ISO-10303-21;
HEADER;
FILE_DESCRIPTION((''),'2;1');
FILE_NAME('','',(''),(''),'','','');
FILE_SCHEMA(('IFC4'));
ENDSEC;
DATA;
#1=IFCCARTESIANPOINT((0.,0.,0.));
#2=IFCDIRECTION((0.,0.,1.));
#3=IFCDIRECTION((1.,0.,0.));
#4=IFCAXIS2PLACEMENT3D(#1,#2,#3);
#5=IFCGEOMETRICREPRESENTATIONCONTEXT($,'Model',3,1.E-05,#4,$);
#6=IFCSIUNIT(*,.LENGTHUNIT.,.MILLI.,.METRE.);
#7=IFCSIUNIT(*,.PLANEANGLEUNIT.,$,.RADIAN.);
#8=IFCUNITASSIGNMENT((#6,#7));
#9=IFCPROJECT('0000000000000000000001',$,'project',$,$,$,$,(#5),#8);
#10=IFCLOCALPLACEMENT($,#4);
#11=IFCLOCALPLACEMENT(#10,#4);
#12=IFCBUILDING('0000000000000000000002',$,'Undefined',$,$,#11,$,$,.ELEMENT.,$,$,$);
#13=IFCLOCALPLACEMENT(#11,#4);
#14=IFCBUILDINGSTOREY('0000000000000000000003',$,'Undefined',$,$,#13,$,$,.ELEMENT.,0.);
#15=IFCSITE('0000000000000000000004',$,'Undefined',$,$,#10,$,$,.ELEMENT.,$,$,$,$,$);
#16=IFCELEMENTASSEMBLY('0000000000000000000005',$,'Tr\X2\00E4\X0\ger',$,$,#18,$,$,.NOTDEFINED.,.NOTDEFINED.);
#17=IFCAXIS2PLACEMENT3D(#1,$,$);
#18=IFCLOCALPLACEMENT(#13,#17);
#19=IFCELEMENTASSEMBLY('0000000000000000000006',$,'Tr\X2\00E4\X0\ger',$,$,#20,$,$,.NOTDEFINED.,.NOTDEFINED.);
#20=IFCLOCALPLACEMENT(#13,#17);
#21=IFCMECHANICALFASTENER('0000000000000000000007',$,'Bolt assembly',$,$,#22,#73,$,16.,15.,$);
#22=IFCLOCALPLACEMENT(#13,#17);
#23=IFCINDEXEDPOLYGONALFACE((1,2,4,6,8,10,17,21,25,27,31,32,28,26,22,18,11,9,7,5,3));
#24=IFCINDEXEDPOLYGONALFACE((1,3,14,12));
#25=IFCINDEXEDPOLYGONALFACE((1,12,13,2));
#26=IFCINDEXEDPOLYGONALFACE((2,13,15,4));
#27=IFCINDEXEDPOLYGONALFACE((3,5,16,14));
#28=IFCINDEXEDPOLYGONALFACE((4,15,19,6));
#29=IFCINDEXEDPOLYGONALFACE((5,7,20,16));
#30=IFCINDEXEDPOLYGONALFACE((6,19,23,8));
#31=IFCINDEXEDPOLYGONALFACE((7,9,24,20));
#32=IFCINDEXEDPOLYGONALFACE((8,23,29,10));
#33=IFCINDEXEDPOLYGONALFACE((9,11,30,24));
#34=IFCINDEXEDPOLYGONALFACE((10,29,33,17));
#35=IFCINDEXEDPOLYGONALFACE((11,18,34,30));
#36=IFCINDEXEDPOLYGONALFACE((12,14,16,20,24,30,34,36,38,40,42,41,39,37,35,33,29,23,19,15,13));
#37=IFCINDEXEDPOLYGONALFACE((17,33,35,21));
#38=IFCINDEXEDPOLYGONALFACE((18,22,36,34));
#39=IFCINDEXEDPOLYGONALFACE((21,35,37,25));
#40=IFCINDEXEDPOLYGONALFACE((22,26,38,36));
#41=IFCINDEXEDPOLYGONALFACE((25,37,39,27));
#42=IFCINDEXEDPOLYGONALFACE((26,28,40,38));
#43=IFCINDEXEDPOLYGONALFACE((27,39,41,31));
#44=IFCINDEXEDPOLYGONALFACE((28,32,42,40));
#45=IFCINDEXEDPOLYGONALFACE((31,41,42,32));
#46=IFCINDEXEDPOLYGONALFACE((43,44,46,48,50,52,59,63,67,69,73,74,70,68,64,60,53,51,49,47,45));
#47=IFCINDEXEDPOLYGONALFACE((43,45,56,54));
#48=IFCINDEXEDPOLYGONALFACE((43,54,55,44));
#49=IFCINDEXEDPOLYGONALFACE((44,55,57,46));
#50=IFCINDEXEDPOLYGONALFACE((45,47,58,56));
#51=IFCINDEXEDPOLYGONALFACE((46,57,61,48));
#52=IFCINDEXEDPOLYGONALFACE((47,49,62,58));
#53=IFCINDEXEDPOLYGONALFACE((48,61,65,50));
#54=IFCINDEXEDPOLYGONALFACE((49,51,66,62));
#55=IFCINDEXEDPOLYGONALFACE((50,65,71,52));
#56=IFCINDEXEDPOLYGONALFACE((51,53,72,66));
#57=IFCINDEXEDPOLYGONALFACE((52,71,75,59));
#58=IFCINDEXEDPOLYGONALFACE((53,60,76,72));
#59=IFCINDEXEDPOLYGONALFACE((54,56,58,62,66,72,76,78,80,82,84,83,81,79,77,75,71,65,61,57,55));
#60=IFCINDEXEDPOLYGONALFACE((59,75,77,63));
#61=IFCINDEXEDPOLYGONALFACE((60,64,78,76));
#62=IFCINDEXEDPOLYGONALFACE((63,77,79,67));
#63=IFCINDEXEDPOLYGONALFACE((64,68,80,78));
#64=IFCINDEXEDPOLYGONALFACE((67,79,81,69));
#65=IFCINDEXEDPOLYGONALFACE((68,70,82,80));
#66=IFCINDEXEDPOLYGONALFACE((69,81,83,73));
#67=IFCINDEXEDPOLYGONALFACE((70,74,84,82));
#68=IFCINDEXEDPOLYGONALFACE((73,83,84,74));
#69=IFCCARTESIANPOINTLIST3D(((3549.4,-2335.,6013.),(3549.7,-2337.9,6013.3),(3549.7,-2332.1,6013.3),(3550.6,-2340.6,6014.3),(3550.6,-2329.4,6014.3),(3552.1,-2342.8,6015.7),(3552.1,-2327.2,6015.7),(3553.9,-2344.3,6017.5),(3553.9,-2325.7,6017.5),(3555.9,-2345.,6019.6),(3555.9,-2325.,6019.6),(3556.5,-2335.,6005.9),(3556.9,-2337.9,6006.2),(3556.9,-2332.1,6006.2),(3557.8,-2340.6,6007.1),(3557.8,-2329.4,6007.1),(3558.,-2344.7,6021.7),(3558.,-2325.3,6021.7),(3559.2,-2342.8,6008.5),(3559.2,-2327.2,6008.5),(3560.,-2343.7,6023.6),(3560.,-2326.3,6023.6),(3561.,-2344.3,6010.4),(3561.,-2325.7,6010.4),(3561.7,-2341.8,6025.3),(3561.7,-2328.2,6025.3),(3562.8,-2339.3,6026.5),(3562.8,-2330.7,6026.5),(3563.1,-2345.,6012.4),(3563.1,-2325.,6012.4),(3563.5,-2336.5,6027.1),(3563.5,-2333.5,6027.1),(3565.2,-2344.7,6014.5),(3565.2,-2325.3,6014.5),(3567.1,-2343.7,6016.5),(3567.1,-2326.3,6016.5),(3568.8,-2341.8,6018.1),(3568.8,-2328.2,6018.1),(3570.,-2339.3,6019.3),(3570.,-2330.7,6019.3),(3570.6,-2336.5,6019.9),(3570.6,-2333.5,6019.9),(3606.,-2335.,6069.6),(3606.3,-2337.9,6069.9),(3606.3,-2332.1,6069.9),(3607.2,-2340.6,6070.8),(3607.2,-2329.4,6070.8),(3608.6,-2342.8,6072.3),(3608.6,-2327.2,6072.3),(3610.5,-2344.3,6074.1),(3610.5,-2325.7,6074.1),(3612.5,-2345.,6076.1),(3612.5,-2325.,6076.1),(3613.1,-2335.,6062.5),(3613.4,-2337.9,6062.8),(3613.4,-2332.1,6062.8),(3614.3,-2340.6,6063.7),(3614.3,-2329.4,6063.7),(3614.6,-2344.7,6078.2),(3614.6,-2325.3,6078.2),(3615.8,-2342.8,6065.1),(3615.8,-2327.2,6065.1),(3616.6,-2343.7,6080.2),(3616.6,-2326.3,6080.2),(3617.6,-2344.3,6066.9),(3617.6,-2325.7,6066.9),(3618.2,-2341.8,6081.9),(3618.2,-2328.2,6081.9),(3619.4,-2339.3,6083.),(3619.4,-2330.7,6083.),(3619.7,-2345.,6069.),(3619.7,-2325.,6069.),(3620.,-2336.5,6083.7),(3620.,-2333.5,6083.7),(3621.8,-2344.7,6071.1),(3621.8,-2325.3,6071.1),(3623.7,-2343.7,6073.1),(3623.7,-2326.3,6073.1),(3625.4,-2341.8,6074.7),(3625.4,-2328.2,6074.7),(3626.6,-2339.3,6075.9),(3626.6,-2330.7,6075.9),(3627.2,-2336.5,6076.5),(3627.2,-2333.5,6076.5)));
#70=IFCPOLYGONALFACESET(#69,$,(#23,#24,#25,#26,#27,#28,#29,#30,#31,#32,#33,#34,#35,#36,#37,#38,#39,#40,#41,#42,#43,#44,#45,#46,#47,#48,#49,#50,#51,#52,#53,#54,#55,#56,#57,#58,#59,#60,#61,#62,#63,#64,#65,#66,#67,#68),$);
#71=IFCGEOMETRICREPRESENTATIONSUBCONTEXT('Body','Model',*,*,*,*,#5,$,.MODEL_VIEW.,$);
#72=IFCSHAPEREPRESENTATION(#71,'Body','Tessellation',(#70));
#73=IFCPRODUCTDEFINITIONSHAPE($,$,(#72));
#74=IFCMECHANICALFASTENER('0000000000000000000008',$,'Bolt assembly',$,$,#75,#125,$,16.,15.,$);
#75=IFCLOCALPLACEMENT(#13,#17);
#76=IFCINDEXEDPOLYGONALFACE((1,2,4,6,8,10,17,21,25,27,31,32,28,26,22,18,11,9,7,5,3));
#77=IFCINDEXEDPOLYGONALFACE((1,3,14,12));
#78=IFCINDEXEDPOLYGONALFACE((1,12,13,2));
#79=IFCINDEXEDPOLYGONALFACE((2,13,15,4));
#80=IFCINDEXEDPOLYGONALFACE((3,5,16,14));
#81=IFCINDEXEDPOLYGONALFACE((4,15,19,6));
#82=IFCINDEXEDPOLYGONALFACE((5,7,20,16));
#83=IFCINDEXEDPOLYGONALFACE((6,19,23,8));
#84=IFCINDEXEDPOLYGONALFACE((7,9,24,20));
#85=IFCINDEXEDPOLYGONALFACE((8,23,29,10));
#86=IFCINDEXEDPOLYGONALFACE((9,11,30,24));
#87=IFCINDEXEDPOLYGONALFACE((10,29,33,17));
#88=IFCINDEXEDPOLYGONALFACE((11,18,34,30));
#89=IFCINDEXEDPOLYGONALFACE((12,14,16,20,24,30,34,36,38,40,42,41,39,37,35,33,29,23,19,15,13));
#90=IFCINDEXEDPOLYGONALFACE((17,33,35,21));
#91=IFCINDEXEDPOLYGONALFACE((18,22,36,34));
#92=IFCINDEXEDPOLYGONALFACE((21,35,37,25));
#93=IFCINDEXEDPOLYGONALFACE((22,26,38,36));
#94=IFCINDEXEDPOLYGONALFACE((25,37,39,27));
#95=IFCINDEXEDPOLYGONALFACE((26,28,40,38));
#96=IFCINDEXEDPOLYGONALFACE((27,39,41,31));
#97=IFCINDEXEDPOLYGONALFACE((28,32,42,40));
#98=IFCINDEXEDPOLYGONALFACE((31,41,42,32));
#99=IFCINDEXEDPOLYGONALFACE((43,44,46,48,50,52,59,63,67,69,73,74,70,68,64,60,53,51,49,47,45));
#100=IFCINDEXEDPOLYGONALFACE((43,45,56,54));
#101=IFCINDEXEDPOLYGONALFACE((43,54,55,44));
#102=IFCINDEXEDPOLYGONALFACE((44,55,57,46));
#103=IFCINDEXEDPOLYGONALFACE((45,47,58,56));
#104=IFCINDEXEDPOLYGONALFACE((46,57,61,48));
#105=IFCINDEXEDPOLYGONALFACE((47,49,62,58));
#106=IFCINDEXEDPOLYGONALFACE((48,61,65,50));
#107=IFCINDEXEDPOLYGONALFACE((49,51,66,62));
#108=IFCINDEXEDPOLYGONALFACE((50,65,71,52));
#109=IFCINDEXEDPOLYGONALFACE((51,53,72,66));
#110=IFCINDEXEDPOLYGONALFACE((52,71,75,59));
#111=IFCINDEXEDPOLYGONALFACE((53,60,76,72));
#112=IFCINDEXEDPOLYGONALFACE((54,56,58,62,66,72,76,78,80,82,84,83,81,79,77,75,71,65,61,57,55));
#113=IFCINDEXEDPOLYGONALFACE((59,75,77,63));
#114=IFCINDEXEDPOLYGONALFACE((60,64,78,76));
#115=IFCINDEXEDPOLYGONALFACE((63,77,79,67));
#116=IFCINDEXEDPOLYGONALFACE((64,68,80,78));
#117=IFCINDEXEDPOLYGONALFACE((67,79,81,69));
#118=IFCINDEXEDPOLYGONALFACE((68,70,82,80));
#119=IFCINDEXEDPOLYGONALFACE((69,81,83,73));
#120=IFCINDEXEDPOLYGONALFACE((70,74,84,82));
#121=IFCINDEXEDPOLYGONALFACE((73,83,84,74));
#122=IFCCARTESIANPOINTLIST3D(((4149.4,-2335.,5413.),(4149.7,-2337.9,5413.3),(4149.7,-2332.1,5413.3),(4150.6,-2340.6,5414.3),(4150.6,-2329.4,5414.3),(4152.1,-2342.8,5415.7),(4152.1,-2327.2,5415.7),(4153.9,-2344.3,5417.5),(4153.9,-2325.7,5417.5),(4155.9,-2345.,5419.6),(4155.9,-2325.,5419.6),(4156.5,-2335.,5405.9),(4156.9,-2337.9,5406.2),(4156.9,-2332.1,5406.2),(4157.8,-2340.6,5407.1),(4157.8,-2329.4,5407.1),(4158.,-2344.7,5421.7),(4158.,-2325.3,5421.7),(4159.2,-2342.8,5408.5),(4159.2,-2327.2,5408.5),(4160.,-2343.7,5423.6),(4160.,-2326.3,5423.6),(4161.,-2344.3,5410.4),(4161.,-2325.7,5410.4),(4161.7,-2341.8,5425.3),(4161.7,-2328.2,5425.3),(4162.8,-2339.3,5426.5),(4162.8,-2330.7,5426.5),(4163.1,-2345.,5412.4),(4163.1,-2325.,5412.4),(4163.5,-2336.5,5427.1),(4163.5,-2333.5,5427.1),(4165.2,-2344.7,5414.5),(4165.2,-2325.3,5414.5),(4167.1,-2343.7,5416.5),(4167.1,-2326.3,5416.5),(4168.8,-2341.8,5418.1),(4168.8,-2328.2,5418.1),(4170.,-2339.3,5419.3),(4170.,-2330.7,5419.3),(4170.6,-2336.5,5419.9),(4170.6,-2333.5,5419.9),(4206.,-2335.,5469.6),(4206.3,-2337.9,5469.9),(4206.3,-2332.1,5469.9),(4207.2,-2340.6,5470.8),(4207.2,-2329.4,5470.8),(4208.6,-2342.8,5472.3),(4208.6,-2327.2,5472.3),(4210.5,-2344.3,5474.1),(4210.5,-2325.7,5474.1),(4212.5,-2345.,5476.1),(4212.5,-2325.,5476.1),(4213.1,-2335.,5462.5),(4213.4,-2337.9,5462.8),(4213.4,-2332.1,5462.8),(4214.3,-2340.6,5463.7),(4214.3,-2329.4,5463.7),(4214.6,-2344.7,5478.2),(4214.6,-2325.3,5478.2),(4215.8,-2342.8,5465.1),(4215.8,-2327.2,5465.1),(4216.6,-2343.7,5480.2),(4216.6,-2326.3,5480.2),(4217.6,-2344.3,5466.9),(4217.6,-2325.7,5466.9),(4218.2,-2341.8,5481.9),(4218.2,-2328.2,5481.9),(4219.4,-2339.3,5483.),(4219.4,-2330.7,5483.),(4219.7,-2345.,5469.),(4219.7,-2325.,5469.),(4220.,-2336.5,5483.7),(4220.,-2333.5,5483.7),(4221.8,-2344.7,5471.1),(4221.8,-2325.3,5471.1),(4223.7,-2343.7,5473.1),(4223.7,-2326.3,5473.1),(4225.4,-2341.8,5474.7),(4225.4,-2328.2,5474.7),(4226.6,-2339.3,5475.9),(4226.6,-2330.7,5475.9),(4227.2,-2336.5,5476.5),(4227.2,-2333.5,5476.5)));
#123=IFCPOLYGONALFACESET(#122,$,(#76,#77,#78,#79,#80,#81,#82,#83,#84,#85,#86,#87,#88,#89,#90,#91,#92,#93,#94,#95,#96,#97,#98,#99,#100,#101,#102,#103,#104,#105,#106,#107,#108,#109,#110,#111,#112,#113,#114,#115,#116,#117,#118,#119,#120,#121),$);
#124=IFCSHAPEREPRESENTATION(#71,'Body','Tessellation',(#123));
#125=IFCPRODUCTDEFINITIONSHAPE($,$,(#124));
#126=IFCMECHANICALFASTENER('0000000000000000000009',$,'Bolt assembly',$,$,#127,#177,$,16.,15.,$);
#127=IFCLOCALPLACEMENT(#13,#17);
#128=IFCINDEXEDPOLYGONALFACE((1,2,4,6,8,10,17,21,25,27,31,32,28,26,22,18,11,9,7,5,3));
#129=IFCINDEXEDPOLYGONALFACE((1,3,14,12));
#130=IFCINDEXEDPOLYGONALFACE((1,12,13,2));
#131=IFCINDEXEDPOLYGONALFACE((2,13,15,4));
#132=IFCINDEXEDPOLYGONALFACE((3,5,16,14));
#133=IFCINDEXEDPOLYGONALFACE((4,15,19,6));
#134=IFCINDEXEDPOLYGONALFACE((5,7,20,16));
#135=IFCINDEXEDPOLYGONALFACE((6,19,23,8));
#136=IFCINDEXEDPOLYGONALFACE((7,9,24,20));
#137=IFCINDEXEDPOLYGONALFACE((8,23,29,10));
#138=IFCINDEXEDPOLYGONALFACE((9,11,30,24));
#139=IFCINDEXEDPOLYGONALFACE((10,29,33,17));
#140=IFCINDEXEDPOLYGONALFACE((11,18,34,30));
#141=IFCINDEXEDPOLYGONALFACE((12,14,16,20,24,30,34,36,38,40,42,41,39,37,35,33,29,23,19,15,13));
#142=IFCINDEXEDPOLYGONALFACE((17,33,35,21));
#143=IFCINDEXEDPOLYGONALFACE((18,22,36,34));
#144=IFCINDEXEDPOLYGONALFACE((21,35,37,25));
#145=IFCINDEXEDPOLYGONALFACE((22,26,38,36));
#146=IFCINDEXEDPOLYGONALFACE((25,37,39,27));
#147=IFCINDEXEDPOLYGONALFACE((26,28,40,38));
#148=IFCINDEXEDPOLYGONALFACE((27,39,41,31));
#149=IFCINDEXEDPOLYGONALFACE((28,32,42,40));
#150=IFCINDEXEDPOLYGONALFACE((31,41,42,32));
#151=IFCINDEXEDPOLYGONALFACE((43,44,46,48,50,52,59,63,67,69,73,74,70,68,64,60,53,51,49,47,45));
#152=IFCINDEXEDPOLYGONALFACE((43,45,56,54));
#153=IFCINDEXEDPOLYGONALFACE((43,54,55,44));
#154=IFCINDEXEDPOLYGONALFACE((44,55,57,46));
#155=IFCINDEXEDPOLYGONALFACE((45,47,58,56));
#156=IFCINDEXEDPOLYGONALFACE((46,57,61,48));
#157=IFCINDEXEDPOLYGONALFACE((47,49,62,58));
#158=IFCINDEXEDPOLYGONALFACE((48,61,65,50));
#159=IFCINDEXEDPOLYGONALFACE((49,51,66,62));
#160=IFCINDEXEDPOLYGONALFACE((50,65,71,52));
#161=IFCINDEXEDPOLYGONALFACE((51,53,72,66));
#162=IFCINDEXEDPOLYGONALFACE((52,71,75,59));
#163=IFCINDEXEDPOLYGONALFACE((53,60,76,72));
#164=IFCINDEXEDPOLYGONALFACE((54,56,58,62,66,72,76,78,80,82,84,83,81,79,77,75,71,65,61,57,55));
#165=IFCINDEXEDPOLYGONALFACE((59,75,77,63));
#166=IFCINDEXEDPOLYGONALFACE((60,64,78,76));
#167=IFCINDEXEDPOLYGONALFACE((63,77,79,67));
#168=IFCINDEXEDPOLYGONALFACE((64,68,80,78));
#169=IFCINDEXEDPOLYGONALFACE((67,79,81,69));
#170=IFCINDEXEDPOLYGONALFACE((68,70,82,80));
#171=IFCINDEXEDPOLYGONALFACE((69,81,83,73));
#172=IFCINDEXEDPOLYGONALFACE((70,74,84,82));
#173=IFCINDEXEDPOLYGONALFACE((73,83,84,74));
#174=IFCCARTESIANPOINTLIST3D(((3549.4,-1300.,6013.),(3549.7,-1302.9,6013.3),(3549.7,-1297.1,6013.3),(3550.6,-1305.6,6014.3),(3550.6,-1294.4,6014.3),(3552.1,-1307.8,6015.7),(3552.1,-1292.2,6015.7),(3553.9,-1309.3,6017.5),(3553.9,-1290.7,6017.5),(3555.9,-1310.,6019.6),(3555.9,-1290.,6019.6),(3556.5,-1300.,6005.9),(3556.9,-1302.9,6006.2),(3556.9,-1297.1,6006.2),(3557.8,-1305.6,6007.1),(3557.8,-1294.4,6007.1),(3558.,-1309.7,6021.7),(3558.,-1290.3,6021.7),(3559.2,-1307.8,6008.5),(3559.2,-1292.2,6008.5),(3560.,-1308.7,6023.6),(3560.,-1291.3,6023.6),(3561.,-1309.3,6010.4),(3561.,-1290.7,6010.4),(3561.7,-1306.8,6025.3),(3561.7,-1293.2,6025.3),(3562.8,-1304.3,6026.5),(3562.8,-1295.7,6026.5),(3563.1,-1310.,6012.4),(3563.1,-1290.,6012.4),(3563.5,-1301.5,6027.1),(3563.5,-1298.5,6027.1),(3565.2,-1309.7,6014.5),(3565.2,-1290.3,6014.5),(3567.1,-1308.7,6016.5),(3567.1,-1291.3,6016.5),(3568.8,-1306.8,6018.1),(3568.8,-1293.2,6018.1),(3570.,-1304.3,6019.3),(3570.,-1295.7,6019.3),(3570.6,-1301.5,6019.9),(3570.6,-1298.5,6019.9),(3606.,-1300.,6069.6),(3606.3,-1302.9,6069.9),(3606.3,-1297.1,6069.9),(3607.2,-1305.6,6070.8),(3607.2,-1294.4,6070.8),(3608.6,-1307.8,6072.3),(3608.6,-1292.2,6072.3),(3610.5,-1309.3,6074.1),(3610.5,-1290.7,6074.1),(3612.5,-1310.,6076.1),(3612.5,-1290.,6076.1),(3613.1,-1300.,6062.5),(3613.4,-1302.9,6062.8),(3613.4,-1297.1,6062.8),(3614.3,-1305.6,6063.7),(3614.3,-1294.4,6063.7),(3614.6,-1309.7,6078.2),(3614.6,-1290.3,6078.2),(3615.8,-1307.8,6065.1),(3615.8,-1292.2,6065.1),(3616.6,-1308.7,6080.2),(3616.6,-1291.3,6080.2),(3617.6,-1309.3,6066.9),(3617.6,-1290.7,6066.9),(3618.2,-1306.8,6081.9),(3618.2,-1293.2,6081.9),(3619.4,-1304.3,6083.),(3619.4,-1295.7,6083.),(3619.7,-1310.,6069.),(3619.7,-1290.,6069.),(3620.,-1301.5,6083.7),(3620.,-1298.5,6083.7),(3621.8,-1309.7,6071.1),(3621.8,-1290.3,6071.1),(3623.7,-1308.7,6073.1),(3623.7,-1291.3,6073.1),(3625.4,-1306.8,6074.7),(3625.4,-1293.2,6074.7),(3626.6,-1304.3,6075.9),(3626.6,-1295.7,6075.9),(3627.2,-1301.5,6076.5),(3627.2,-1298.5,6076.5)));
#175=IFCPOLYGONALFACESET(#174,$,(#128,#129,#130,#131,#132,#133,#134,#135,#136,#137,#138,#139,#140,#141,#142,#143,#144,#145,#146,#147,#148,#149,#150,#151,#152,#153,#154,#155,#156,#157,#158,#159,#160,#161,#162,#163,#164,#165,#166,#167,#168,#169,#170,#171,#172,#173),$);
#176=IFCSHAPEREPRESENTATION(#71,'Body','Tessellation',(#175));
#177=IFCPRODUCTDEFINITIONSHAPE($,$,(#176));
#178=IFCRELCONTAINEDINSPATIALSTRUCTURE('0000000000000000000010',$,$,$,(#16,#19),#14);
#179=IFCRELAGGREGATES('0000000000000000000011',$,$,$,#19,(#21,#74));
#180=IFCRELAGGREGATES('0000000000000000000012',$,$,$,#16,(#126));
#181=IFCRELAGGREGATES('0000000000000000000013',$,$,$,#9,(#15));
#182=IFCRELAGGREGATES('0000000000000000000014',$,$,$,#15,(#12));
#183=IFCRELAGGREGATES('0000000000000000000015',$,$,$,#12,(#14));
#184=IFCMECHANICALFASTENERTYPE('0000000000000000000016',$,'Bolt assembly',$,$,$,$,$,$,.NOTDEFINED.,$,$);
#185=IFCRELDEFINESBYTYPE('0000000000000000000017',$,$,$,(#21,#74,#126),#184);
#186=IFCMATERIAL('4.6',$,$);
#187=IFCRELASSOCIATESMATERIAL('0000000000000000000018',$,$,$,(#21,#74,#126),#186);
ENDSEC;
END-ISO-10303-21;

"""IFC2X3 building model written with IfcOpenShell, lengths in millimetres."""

from ifc_helpers import new_model, si_unit, frame, origin_with_axes, origin_2d_with_axis, place, context, subcontext, project, spatial, circle, extrude, source, transform, mapped, material, type_object, element, aggregate, save


model = new_model("IFC2X3")

# Units and contexts
model_context = context("Model", 3, precision=1e-05, world=origin_with_axes())
body_context = subcontext(model_context, "Body", "Model", "MODEL_VIEW")
ifc_project = project(units=[si_unit("LENGTHUNIT", "METRE", prefix="MILLI"), si_unit("PLANEANGLEUNIT", "RADIAN")], contexts=[model_context])

# Site, building, storey
site_placement = place(None, origin_with_axes())
site = spatial("IfcSite", under=ifc_project, at=site_placement, Name="Undefined", CompositionType="ELEMENT")
building_placement = place(site_placement, origin_with_axes())
building = spatial("IfcBuilding", under=site, at=building_placement, Name="Undefined", CompositionType="ELEMENT")
storey_placement = place(building_placement, origin_with_axes())
storey = spatial("IfcBuildingStorey", under=building, at=storey_placement, Name="Undefined", CompositionType="ELEMENT", Elevation=0.0)

# Element assembly
assembly_1_placement = place(storey_placement, origin_with_axes())
assembly_1 = element("IfcElementAssembly", 1, at=assembly_1_placement, inside=storey, Name="Träger", AssemblyPlace="NOTDEFINED", PredefinedType="NOTDEFINED")

# Element assembly
assembly_2_placement = place(storey_placement, origin_with_axes())
assembly_2 = element("IfcElementAssembly", 2, at=assembly_2_placement, inside=storey, Name="Träger", AssemblyPlace="NOTDEFINED", PredefinedType="NOTDEFINED")

# Mechanical fasteners
ifc_material_1 = material(Name="4.6")
mechanical_fastener_type = type_object("IfcMechanicalFastenerType", Name="Bolt assembly")
shared_shape_1 = source(origin_with_axes(), body_context, "Body", "SweptSolid", [
    extrude(circle(Radius=10.0, at=origin_2d_with_axis()), frame((0.0, 0.0, 0.0), z_axis=(0.0, 1.0, 0.0), x_axis=(1.0, 0.0, 0.0)), (0.0, 0.0, 1.0), 10.1),
])
mechanical_fastener_1_placement = place(assembly_2_placement, frame((3613.0, -2335.0, 6076.7), z_axis=(0.0, -1.0, 0.0), x_axis=(-0.707107, 0.0, -0.707107)))
mechanical_fastener_1 = element("IfcMechanicalFastener", 3, at=mechanical_fastener_1_placement, type_object=mechanical_fastener_type, material=ifc_material_1, Name="Bolt assembly", NominalDiameter=16.0, NominalLength=15.0, context=body_context, shape_type="MappedRepresentation", body=[
    mapped(shared_shape_1, transform((0.0, 0.0, 0.0))),
    mapped(shared_shape_1, transform((80.0, 0.0, 0.0))),
])
mechanical_fastener_2_placement = place(assembly_2_placement, frame((4213.0, -2335.0, 5476.7), z_axis=(0.0, -1.0, 0.0), x_axis=(-0.707107, 0.0, -0.707107)))
mechanical_fastener_2 = element("IfcMechanicalFastener", 4, at=mechanical_fastener_2_placement, type_object=mechanical_fastener_type, material=ifc_material_1, Name="Bolt assembly", NominalDiameter=16.0, NominalLength=15.0, context=body_context, shape_type="MappedRepresentation", body=[
    mapped(shared_shape_1, transform((0.0, 0.0, 0.0))),
    mapped(shared_shape_1, transform((80.0, 0.0, 0.0))),
])
aggregate(assembly_2, [mechanical_fastener_1, mechanical_fastener_2])
mechanical_fastener_3_placement = place(assembly_1_placement, frame((3613.0, -1300.0, 6076.7), z_axis=(0.0, -1.0, 0.0), x_axis=(-0.707107, 0.0, -0.707107)))
mechanical_fastener_3 = element("IfcMechanicalFastener", 5, at=mechanical_fastener_3_placement, type_object=mechanical_fastener_type, material=ifc_material_1, Name="Bolt assembly", NominalDiameter=16.0, NominalLength=15.0, context=body_context, shape_type="MappedRepresentation", body=[
    mapped(shared_shape_1, transform((0.0, 0.0, 0.0))),
    mapped(shared_shape_1, transform((80.0, 0.0, 0.0))),
])
aggregate(assembly_1, [mechanical_fastener_3])

save(model, "model.ifc")
